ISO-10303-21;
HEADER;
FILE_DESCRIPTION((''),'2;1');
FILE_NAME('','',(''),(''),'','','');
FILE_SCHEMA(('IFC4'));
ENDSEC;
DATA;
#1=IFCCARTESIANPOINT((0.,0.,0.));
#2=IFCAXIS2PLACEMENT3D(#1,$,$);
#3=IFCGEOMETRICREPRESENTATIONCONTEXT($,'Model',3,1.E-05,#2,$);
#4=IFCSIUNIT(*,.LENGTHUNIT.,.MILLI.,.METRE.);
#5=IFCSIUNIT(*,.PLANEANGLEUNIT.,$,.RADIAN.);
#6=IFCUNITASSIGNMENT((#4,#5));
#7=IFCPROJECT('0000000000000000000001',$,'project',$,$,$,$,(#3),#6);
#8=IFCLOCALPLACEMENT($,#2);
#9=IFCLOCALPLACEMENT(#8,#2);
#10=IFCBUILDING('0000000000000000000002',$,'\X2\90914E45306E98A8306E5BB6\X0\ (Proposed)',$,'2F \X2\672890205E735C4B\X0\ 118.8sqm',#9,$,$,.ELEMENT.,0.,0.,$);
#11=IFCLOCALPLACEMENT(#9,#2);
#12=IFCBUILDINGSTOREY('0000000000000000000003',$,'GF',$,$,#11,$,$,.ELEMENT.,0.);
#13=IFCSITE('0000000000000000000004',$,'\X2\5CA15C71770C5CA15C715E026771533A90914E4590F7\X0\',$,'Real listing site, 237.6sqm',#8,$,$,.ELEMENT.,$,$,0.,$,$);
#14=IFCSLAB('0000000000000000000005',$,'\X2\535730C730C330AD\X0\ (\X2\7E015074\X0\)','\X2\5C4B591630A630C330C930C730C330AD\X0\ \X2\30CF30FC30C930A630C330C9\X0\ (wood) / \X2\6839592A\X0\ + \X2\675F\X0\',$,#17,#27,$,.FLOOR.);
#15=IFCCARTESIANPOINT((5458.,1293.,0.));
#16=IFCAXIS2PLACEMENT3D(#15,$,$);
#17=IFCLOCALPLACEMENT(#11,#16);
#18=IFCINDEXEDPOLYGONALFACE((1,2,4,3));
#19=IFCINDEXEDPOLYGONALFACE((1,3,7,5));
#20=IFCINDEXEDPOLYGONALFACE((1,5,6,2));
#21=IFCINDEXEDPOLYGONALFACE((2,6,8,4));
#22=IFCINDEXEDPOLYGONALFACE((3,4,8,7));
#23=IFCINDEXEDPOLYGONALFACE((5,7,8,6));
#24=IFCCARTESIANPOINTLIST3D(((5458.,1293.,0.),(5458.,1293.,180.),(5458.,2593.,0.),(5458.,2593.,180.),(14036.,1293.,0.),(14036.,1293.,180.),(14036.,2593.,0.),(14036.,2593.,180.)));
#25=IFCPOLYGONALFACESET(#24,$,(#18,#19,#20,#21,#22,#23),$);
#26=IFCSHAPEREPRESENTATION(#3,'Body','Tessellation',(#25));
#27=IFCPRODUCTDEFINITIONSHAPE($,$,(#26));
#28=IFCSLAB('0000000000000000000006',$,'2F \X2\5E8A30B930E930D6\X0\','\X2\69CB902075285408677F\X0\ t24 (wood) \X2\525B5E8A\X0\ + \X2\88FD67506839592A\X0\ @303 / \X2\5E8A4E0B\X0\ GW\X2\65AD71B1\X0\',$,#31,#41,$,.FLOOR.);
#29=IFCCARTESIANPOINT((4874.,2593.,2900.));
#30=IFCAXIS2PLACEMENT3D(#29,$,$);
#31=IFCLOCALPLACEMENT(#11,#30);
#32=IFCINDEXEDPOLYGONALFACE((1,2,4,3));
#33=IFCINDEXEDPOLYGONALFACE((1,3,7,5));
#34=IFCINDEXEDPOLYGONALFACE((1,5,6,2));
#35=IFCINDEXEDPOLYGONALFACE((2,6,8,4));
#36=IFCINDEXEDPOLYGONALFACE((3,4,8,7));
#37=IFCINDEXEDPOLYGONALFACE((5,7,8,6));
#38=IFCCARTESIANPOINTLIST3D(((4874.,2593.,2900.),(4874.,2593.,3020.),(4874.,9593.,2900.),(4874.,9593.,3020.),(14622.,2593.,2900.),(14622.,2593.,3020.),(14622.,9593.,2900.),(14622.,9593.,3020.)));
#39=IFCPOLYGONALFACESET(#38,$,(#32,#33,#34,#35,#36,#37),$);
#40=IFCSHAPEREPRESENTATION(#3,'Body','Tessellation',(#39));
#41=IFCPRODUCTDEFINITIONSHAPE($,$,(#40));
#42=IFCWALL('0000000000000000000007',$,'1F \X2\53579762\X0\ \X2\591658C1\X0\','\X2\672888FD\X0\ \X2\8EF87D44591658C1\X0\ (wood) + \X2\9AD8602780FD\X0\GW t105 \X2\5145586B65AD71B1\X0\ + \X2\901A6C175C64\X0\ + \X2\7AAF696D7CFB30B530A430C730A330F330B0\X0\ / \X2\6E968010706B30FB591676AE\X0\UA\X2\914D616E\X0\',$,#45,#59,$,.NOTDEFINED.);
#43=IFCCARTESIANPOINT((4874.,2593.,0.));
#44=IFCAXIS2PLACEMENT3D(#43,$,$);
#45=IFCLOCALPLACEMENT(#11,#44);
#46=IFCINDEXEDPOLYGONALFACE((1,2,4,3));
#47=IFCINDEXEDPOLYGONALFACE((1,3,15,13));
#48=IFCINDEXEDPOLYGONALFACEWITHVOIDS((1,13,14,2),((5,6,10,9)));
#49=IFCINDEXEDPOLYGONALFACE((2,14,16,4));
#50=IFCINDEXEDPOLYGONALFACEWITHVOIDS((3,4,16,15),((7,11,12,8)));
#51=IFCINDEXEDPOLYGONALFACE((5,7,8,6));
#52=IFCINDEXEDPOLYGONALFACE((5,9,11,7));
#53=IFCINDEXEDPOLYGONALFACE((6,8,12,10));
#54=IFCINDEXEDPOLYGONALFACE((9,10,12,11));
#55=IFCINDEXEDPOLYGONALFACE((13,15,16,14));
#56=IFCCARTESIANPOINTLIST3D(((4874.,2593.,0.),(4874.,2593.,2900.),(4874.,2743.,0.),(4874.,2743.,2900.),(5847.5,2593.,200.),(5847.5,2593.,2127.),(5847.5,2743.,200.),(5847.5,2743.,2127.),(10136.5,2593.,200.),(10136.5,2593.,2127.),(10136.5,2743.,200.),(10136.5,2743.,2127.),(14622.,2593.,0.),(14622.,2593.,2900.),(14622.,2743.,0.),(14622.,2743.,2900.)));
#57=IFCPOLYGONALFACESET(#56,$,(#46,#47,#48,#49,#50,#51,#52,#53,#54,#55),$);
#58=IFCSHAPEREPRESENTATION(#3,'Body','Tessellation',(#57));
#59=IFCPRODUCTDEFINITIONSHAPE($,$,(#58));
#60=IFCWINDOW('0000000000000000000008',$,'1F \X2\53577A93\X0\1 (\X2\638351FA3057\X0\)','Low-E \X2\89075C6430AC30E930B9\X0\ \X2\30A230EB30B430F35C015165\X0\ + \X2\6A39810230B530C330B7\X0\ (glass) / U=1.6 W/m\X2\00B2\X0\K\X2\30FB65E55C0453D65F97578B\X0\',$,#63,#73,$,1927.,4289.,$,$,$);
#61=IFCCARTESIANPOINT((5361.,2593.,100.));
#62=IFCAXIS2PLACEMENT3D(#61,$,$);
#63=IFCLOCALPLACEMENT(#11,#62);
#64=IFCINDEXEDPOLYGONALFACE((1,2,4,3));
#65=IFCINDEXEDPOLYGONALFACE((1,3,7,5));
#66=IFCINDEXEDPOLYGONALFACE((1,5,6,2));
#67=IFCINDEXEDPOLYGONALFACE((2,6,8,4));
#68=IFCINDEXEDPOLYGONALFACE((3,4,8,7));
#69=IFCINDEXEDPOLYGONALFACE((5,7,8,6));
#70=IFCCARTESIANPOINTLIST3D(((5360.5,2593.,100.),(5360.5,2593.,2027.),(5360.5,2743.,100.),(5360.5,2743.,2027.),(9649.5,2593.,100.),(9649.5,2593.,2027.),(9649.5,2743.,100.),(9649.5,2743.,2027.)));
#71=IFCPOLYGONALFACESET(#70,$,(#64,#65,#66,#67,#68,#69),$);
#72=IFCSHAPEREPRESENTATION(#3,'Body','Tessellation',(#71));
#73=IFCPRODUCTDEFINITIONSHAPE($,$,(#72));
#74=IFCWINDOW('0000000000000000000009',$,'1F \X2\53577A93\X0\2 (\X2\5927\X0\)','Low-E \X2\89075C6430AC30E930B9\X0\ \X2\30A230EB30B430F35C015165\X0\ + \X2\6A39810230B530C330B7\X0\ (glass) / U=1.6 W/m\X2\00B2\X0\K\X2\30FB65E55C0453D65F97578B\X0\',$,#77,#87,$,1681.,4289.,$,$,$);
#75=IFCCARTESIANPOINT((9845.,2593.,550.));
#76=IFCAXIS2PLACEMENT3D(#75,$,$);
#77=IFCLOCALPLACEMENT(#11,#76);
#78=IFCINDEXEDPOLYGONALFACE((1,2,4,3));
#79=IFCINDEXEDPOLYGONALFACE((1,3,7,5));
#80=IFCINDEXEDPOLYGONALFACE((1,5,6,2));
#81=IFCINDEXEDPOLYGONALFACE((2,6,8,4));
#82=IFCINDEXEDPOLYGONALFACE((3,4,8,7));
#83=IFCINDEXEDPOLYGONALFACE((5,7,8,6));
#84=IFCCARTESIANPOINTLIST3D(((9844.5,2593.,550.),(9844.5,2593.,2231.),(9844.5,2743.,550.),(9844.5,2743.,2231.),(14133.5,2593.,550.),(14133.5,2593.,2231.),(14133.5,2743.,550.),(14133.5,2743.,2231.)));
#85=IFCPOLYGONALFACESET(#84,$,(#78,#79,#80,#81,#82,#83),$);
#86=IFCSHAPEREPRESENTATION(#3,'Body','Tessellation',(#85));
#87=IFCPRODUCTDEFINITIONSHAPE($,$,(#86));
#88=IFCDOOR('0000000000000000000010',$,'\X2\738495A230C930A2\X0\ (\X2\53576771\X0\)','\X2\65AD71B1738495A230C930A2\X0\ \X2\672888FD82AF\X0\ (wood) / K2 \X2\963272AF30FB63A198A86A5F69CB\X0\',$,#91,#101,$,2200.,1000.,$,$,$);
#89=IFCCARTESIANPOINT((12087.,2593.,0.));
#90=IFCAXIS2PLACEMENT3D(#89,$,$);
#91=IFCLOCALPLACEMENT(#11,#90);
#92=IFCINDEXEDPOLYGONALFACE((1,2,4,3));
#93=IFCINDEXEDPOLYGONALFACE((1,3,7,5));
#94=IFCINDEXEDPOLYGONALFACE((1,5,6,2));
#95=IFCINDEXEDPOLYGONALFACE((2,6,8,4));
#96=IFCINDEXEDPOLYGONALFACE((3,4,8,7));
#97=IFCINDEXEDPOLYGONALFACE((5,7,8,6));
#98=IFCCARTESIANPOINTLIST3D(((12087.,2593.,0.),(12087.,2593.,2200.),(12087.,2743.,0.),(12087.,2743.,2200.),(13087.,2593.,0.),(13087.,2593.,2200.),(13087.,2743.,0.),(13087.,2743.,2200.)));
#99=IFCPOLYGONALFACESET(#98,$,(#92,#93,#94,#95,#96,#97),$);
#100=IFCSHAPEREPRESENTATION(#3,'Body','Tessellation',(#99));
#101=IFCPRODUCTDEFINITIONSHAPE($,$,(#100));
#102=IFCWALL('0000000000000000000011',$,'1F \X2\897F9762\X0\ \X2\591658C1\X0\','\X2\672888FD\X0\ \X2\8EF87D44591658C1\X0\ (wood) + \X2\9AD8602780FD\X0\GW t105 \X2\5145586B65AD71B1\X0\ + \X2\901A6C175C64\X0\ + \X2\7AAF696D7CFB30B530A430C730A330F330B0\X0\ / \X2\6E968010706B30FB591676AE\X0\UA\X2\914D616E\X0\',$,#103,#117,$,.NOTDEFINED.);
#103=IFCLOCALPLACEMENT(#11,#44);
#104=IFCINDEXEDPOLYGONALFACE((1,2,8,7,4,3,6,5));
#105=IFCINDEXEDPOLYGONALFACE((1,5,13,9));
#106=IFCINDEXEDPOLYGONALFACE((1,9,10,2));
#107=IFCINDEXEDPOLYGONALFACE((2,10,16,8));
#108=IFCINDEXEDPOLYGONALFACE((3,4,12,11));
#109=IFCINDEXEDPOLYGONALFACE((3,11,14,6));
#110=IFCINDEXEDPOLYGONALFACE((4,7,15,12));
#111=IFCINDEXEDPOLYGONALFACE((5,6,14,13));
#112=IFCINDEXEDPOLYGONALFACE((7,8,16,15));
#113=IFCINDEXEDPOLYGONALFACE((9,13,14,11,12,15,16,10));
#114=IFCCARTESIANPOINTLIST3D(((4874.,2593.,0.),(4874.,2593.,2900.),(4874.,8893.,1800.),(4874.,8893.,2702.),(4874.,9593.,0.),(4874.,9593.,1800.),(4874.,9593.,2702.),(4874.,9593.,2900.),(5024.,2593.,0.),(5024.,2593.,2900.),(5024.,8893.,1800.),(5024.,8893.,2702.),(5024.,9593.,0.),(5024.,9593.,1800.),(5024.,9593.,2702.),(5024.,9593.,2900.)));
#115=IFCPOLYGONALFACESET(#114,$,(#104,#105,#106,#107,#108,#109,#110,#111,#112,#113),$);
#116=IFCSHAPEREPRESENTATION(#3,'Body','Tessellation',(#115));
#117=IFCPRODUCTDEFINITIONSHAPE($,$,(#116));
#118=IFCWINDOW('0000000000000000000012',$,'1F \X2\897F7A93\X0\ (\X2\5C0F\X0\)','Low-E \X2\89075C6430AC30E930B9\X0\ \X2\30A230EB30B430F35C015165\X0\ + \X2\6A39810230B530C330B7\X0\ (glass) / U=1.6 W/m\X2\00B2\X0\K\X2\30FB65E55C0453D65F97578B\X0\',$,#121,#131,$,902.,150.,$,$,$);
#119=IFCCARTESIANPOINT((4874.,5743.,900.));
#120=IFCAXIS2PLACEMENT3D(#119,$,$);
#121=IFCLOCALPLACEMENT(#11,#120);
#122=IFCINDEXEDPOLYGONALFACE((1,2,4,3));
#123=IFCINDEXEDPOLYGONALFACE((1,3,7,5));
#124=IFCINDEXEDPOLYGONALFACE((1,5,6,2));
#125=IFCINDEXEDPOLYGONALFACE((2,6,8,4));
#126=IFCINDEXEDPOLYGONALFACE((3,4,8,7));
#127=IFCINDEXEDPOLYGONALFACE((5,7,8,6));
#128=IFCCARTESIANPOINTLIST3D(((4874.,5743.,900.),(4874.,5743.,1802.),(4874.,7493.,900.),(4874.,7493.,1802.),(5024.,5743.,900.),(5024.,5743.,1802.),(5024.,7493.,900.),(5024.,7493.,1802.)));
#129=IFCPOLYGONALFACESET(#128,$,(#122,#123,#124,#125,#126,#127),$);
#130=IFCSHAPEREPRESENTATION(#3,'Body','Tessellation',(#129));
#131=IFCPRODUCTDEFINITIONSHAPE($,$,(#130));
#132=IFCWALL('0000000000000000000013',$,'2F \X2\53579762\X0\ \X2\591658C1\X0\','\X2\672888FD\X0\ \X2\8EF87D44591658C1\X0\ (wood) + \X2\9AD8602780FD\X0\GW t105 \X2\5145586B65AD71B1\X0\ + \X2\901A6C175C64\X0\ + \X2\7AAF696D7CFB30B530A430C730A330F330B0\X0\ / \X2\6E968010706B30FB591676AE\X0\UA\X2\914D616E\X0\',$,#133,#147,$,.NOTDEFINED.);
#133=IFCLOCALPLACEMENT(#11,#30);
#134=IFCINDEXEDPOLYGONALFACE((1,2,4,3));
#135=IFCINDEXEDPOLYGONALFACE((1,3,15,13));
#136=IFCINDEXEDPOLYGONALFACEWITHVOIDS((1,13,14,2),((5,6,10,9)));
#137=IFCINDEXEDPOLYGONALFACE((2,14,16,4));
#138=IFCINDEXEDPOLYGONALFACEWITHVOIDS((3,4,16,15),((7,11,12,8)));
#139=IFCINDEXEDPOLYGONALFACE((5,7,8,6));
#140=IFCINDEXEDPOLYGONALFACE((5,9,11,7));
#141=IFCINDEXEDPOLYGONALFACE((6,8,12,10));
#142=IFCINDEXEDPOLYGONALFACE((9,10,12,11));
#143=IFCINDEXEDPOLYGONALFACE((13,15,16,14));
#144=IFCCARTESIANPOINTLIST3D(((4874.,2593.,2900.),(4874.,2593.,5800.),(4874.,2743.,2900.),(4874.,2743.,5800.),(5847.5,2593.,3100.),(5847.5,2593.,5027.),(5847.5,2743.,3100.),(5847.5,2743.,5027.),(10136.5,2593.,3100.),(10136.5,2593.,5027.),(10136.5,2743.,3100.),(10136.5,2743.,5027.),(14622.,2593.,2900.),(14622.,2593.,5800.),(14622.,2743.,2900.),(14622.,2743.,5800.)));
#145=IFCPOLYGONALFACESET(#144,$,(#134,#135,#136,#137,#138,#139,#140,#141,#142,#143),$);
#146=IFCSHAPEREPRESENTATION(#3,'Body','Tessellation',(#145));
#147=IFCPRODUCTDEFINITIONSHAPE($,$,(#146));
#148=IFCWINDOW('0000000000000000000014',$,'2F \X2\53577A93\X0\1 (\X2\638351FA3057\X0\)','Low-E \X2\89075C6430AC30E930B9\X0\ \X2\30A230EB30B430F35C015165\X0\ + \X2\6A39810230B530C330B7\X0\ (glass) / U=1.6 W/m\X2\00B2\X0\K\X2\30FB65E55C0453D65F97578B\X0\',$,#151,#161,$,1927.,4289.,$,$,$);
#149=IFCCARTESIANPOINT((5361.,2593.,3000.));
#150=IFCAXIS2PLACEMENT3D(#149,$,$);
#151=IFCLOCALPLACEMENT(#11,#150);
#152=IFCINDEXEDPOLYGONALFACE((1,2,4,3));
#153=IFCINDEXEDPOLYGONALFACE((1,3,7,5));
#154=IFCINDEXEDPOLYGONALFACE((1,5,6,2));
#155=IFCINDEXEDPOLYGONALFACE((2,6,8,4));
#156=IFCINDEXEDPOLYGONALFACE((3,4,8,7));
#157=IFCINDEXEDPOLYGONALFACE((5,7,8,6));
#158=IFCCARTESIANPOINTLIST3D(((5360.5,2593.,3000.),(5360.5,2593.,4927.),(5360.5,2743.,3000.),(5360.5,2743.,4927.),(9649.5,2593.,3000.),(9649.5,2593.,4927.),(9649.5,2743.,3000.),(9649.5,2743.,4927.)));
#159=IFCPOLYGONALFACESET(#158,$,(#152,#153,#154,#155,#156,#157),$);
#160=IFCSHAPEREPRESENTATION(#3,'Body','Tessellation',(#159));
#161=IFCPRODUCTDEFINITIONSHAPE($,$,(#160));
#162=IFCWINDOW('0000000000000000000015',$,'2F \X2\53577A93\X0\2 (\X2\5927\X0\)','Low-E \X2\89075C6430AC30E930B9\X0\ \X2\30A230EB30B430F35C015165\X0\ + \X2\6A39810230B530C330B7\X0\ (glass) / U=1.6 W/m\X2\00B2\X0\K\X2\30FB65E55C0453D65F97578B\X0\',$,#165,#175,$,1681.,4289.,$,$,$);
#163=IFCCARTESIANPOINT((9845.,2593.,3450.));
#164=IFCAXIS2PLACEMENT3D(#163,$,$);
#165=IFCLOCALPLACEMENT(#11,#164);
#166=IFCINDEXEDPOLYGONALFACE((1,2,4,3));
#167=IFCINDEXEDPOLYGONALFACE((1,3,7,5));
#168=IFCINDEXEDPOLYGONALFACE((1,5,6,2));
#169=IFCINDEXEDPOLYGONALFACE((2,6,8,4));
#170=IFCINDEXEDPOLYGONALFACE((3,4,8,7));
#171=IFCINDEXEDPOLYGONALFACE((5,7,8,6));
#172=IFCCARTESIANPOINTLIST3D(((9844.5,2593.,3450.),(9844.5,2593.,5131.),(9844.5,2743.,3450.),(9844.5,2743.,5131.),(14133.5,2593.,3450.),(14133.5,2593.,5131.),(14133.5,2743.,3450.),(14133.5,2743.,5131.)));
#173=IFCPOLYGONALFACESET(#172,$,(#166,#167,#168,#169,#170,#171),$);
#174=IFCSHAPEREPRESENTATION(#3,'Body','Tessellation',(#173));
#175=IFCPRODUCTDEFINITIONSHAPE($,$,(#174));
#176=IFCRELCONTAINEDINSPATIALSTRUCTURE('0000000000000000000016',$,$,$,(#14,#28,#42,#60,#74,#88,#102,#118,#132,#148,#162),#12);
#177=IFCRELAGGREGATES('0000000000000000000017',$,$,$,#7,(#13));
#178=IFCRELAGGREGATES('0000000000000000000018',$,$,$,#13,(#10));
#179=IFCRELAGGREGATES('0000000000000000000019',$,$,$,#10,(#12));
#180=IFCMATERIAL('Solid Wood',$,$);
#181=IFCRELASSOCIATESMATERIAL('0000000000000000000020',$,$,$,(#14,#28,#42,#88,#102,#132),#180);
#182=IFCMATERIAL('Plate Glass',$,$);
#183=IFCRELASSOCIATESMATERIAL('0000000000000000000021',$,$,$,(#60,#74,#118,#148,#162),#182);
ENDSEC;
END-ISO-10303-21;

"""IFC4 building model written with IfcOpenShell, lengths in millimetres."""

from ifc_helpers import new_model, si_unit, frame, frame_2d, origin, place, context, project, spatial, rectangle, extrude, material, element, fill, save


model = new_model("IFC4")

# Units and contexts
model_context = context("Model", 3, precision=1e-05, world=origin())
ifc_project = project(units=[si_unit("LENGTHUNIT", "METRE", prefix="MILLI"), si_unit("PLANEANGLEUNIT", "RADIAN")], contexts=[model_context])

# Site, building, storey
site_placement = place(None, origin())
site = spatial("IfcSite", under=ifc_project, at=site_placement, Name="岡山県岡山市東区邑久郷", ObjectType="Real listing site, 237.6sqm", CompositionType="ELEMENT", RefElevation=0.0)
building_placement = place(site_placement, origin())
building = spatial("IfcBuilding", under=site, at=building_placement, Name="邑久の風の家 (Proposed)", ObjectType="2F 木造平屋 118.8sqm", CompositionType="ELEMENT", ElevationOfRefHeight=0.0, ElevationOfTerrain=0.0)
storey_placement = place(building_placement, origin())
storey = spatial("IfcBuildingStorey", under=building, at=storey_placement, Name="GF", CompositionType="ELEMENT", Elevation=0.0)

# Slabs
ifc_material_1 = material(Name="Solid Wood")
slab_1_placement = place(storey_placement, frame((5458.0, 1293.0, 0.0)))
element("IfcSlab", 1, at=slab_1_placement, inside=storey, material=ifc_material_1, Name="南デッキ (縁側)", Description="屋外ウッドデッキ ハードウッド (wood) / 根太 + 束", PredefinedType="FLOOR", context=model_context, shape_type="SweptSolid", body=[
    extrude(rectangle(XDim=8578.0, YDim=1300.0, at=frame_2d((4289.0, 650.0))), frame((5458.0, 1293.0, 0.0)), (0.0, 0.0, 1.0), 180.0),
])
slab_2_placement = place(storey_placement, frame((4874.0, 2593.0, 2900.0)))
element("IfcSlab", 2, at=slab_2_placement, inside=storey, material=ifc_material_1, Name="2F 床スラブ", Description="構造用合板 t24 (wood) 剛床 + 製材根太 @303 / 床下 GW断熱", PredefinedType="FLOOR", context=model_context, shape_type="SweptSolid", body=[
    extrude(rectangle(XDim=9748.0, YDim=7000.0, at=frame_2d((4874.0, 3500.0))), frame((4874.0, 2593.0, 2900.0)), (0.0, 0.0, 1.0), 120.0),
])

# Wall, openings, windows, door
wall_1_placement = place(storey_placement, frame((4874.0, 2593.0, 0.0)))
wall_1 = element("IfcWall", 3, at=wall_1_placement, inside=storey, material=ifc_material_1, Name="1F 南面 外壁", Description="木製 軸組外壁 (wood) + 高性能GW t105 充填断熱 + 通気層 + 窯業系サイディング / 準耐火・外皮UA配慮", PredefinedType="NOTDEFINED", context=model_context, shape_type="SweptSolid", body=[
    extrude(rectangle(XDim=9748.0, YDim=150.0, at=frame_2d((4874.0, 75.0))), frame((4874.0, 2593.0, 0.0)), (0.0, 0.0, 1.0), 2900.0),
])
opening_1_placement = place(storey_placement, frame((5361.0, 2593.0, 100.0)))
opening_1 = element("IfcOpeningElement", 4, at=opening_1_placement, cuts=wall_1, PredefinedType="NOTDEFINED", context=model_context, shape_type="SweptSolid", body=[
    extrude(rectangle(XDim=4289.0, YDim=150.0, at=frame_2d((2144.0, 75.0))), frame((5361.0, 2593.0, 100.0)), (0.0, 0.0, 1.0), 1927.0),
])
opening_2_placement = place(storey_placement, frame((9845.0, 2593.0, 550.0)))
opening_2 = element("IfcOpeningElement", 5, at=opening_2_placement, cuts=wall_1, PredefinedType="NOTDEFINED", context=model_context, shape_type="SweptSolid", body=[
    extrude(rectangle(XDim=4289.0, YDim=150.0, at=frame_2d((2144.0, 75.0))), frame((9845.0, 2593.0, 550.0)), (0.0, 0.0, 1.0), 1681.0),
])
opening_3_placement = place(storey_placement, frame((12087.0, 2593.0, 0.0)))
opening_3 = element("IfcOpeningElement", 6, at=opening_3_placement, cuts=wall_1, PredefinedType="NOTDEFINED", context=model_context, shape_type="SweptSolid", body=[
    extrude(rectangle(XDim=1000.0, YDim=150.0, at=frame_2d((500.0, 75.0))), frame((12087.0, 2593.0, 0.0)), (0.0, 0.0, 1.0), 2200.0),
])
ifc_material_2 = material(Name="Plate Glass")
window_1_placement = place(storey_placement, frame((5361.0, 2593.0, 100.0)))
window_1 = element("IfcWindow", 7, at=window_1_placement, inside=storey, material=ifc_material_2, Name="1F 南窓1 (掃出し)", Description="Low-E 複層ガラス アルゴン封入 + 樹脂サッシ (glass) / U=1.6 W/m²K・日射取得型", OverallHeight=1927.0, OverallWidth=4289.0, context=model_context, shape_type="SweptSolid", body=[
    extrude(rectangle(XDim=4289.0, YDim=150.0, at=frame_2d((2144.0, 75.0))), frame((5361.0, 2593.0, 100.0)), (0.0, 0.0, 1.0), 1927.0),
])
fill(opening_1, window_1)
window_2_placement = place(storey_placement, frame((9845.0, 2593.0, 550.0)))
window_2 = element("IfcWindow", 8, at=window_2_placement, inside=storey, material=ifc_material_2, Name="1F 南窓2 (大)", Description="Low-E 複層ガラス アルゴン封入 + 樹脂サッシ (glass) / U=1.6 W/m²K・日射取得型", OverallHeight=1681.0, OverallWidth=4289.0, context=model_context, shape_type="SweptSolid", body=[
    extrude(rectangle(XDim=4289.0, YDim=150.0, at=frame_2d((2144.0, 75.0))), frame((9845.0, 2593.0, 550.0)), (0.0, 0.0, 1.0), 1681.0),
])
fill(opening_2, window_2)
door_placement = place(storey_placement, frame((12087.0, 2593.0, 0.0)))
door = element("IfcDoor", 9, at=door_placement, inside=storey, material=ifc_material_1, Name="玄関ドア (南東)", Description="断熱玄関ドア 木製芯 (wood) / K2 防犯・採風機構", OverallHeight=2200.0, OverallWidth=1000.0, context=model_context, shape_type="SweptSolid", body=[
    extrude(rectangle(XDim=1000.0, YDim=150.0, at=frame_2d((500.0, 75.0))), frame((12087.0, 2593.0, 0.0)), (0.0, 0.0, 1.0), 2200.0),
])
fill(opening_3, door)

# Wall, opening, window
wall_2_placement = place(storey_placement, frame((4874.0, 2593.0, 0.0)))
wall_2 = element("IfcWall", 10, at=wall_2_placement, inside=storey, material=ifc_material_1, Name="1F 西面 外壁", Description="木製 軸組外壁 (wood) + 高性能GW t105 充填断熱 + 通気層 + 窯業系サイディング / 準耐火・外皮UA配慮", PredefinedType="NOTDEFINED", context=model_context, shape_type="SweptSolid", body=[
    extrude(rectangle(XDim=150.0, YDim=7000.0, at=frame_2d((75.0, 3500.0))), frame((4874.0, 2593.0, 0.0)), (0.0, 0.0, 1.0), 2900.0),
])
opening_4_placement = place(storey_placement, frame((4874.0, 5743.0, 900.0)))
opening_4 = element("IfcOpeningElement", 11, at=opening_4_placement, cuts=wall_2, PredefinedType="NOTDEFINED", context=model_context, shape_type="SweptSolid", body=[
    extrude(rectangle(XDim=150.0, YDim=1750.0, at=frame_2d((75.0, 875.0))), frame((4874.0, 5743.0, 900.0)), (0.0, 0.0, 1.0), 902.0),
])
window_3_placement = place(storey_placement, frame((4874.0, 5743.0, 900.0)))
window_3 = element("IfcWindow", 12, at=window_3_placement, inside=storey, material=ifc_material_2, Name="1F 西窓 (小)", Description="Low-E 複層ガラス アルゴン封入 + 樹脂サッシ (glass) / U=1.6 W/m²K・日射取得型", OverallHeight=902.0, OverallWidth=150.0, context=model_context, shape_type="SweptSolid", body=[
    extrude(rectangle(XDim=150.0, YDim=1750.0, at=frame_2d((75.0, 875.0))), frame((4874.0, 5743.0, 900.0)), (0.0, 0.0, 1.0), 902.0),
])
fill(opening_4, window_3)

# Wall, openings, windows
wall_3_placement = place(storey_placement, frame((4874.0, 2593.0, 2900.0)))
wall_3 = element("IfcWall", 13, at=wall_3_placement, inside=storey, material=ifc_material_1, Name="2F 南面 外壁", Description="木製 軸組外壁 (wood) + 高性能GW t105 充填断熱 + 通気層 + 窯業系サイディング / 準耐火・外皮UA配慮", PredefinedType="NOTDEFINED", context=model_context, shape_type="SweptSolid", body=[
    extrude(rectangle(XDim=9748.0, YDim=150.0, at=frame_2d((4874.0, 75.0))), frame((4874.0, 2593.0, 2900.0)), (0.0, 0.0, 1.0), 2900.0),
])
opening_5_placement = place(storey_placement, frame((5361.0, 2593.0, 3000.0)))
opening_5 = element("IfcOpeningElement", 14, at=opening_5_placement, cuts=wall_3, PredefinedType="NOTDEFINED", context=model_context, shape_type="SweptSolid", body=[
    extrude(rectangle(XDim=4289.0, YDim=150.0, at=frame_2d((2144.0, 75.0))), frame((5361.0, 2593.0, 3000.0)), (0.0, 0.0, 1.0), 1927.0),
])
opening_6_placement = place(storey_placement, frame((9845.0, 2593.0, 3450.0)))
opening_6 = element("IfcOpeningElement", 15, at=opening_6_placement, cuts=wall_3, PredefinedType="NOTDEFINED", context=model_context, shape_type="SweptSolid", body=[
    extrude(rectangle(XDim=4289.0, YDim=150.0, at=frame_2d((2144.0, 75.0))), frame((9845.0, 2593.0, 3450.0)), (0.0, 0.0, 1.0), 1681.0),
])
window_4_placement = place(storey_placement, frame((5361.0, 2593.0, 3000.0)))
window_4 = element("IfcWindow", 16, at=window_4_placement, inside=storey, material=ifc_material_2, Name="2F 南窓1 (掃出し)", Description="Low-E 複層ガラス アルゴン封入 + 樹脂サッシ (glass) / U=1.6 W/m²K・日射取得型", OverallHeight=1927.0, OverallWidth=4289.0, context=model_context, shape_type="SweptSolid", body=[
    extrude(rectangle(XDim=4289.0, YDim=150.0, at=frame_2d((2144.0, 75.0))), frame((5361.0, 2593.0, 3000.0)), (0.0, 0.0, 1.0), 1927.0),
])
fill(opening_5, window_4)
window_5_placement = place(storey_placement, frame((9845.0, 2593.0, 3450.0)))
window_5 = element("IfcWindow", 17, at=window_5_placement, inside=storey, material=ifc_material_2, Name="2F 南窓2 (大)", Description="Low-E 複層ガラス アルゴン封入 + 樹脂サッシ (glass) / U=1.6 W/m²K・日射取得型", OverallHeight=1681.0, OverallWidth=4289.0, context=model_context, shape_type="SweptSolid", body=[
    extrude(rectangle(XDim=4289.0, YDim=150.0, at=frame_2d((2144.0, 75.0))), frame((9845.0, 2593.0, 3450.0)), (0.0, 0.0, 1.0), 1681.0),
])
fill(opening_6, window_5)

save(model, "model.ifc")
